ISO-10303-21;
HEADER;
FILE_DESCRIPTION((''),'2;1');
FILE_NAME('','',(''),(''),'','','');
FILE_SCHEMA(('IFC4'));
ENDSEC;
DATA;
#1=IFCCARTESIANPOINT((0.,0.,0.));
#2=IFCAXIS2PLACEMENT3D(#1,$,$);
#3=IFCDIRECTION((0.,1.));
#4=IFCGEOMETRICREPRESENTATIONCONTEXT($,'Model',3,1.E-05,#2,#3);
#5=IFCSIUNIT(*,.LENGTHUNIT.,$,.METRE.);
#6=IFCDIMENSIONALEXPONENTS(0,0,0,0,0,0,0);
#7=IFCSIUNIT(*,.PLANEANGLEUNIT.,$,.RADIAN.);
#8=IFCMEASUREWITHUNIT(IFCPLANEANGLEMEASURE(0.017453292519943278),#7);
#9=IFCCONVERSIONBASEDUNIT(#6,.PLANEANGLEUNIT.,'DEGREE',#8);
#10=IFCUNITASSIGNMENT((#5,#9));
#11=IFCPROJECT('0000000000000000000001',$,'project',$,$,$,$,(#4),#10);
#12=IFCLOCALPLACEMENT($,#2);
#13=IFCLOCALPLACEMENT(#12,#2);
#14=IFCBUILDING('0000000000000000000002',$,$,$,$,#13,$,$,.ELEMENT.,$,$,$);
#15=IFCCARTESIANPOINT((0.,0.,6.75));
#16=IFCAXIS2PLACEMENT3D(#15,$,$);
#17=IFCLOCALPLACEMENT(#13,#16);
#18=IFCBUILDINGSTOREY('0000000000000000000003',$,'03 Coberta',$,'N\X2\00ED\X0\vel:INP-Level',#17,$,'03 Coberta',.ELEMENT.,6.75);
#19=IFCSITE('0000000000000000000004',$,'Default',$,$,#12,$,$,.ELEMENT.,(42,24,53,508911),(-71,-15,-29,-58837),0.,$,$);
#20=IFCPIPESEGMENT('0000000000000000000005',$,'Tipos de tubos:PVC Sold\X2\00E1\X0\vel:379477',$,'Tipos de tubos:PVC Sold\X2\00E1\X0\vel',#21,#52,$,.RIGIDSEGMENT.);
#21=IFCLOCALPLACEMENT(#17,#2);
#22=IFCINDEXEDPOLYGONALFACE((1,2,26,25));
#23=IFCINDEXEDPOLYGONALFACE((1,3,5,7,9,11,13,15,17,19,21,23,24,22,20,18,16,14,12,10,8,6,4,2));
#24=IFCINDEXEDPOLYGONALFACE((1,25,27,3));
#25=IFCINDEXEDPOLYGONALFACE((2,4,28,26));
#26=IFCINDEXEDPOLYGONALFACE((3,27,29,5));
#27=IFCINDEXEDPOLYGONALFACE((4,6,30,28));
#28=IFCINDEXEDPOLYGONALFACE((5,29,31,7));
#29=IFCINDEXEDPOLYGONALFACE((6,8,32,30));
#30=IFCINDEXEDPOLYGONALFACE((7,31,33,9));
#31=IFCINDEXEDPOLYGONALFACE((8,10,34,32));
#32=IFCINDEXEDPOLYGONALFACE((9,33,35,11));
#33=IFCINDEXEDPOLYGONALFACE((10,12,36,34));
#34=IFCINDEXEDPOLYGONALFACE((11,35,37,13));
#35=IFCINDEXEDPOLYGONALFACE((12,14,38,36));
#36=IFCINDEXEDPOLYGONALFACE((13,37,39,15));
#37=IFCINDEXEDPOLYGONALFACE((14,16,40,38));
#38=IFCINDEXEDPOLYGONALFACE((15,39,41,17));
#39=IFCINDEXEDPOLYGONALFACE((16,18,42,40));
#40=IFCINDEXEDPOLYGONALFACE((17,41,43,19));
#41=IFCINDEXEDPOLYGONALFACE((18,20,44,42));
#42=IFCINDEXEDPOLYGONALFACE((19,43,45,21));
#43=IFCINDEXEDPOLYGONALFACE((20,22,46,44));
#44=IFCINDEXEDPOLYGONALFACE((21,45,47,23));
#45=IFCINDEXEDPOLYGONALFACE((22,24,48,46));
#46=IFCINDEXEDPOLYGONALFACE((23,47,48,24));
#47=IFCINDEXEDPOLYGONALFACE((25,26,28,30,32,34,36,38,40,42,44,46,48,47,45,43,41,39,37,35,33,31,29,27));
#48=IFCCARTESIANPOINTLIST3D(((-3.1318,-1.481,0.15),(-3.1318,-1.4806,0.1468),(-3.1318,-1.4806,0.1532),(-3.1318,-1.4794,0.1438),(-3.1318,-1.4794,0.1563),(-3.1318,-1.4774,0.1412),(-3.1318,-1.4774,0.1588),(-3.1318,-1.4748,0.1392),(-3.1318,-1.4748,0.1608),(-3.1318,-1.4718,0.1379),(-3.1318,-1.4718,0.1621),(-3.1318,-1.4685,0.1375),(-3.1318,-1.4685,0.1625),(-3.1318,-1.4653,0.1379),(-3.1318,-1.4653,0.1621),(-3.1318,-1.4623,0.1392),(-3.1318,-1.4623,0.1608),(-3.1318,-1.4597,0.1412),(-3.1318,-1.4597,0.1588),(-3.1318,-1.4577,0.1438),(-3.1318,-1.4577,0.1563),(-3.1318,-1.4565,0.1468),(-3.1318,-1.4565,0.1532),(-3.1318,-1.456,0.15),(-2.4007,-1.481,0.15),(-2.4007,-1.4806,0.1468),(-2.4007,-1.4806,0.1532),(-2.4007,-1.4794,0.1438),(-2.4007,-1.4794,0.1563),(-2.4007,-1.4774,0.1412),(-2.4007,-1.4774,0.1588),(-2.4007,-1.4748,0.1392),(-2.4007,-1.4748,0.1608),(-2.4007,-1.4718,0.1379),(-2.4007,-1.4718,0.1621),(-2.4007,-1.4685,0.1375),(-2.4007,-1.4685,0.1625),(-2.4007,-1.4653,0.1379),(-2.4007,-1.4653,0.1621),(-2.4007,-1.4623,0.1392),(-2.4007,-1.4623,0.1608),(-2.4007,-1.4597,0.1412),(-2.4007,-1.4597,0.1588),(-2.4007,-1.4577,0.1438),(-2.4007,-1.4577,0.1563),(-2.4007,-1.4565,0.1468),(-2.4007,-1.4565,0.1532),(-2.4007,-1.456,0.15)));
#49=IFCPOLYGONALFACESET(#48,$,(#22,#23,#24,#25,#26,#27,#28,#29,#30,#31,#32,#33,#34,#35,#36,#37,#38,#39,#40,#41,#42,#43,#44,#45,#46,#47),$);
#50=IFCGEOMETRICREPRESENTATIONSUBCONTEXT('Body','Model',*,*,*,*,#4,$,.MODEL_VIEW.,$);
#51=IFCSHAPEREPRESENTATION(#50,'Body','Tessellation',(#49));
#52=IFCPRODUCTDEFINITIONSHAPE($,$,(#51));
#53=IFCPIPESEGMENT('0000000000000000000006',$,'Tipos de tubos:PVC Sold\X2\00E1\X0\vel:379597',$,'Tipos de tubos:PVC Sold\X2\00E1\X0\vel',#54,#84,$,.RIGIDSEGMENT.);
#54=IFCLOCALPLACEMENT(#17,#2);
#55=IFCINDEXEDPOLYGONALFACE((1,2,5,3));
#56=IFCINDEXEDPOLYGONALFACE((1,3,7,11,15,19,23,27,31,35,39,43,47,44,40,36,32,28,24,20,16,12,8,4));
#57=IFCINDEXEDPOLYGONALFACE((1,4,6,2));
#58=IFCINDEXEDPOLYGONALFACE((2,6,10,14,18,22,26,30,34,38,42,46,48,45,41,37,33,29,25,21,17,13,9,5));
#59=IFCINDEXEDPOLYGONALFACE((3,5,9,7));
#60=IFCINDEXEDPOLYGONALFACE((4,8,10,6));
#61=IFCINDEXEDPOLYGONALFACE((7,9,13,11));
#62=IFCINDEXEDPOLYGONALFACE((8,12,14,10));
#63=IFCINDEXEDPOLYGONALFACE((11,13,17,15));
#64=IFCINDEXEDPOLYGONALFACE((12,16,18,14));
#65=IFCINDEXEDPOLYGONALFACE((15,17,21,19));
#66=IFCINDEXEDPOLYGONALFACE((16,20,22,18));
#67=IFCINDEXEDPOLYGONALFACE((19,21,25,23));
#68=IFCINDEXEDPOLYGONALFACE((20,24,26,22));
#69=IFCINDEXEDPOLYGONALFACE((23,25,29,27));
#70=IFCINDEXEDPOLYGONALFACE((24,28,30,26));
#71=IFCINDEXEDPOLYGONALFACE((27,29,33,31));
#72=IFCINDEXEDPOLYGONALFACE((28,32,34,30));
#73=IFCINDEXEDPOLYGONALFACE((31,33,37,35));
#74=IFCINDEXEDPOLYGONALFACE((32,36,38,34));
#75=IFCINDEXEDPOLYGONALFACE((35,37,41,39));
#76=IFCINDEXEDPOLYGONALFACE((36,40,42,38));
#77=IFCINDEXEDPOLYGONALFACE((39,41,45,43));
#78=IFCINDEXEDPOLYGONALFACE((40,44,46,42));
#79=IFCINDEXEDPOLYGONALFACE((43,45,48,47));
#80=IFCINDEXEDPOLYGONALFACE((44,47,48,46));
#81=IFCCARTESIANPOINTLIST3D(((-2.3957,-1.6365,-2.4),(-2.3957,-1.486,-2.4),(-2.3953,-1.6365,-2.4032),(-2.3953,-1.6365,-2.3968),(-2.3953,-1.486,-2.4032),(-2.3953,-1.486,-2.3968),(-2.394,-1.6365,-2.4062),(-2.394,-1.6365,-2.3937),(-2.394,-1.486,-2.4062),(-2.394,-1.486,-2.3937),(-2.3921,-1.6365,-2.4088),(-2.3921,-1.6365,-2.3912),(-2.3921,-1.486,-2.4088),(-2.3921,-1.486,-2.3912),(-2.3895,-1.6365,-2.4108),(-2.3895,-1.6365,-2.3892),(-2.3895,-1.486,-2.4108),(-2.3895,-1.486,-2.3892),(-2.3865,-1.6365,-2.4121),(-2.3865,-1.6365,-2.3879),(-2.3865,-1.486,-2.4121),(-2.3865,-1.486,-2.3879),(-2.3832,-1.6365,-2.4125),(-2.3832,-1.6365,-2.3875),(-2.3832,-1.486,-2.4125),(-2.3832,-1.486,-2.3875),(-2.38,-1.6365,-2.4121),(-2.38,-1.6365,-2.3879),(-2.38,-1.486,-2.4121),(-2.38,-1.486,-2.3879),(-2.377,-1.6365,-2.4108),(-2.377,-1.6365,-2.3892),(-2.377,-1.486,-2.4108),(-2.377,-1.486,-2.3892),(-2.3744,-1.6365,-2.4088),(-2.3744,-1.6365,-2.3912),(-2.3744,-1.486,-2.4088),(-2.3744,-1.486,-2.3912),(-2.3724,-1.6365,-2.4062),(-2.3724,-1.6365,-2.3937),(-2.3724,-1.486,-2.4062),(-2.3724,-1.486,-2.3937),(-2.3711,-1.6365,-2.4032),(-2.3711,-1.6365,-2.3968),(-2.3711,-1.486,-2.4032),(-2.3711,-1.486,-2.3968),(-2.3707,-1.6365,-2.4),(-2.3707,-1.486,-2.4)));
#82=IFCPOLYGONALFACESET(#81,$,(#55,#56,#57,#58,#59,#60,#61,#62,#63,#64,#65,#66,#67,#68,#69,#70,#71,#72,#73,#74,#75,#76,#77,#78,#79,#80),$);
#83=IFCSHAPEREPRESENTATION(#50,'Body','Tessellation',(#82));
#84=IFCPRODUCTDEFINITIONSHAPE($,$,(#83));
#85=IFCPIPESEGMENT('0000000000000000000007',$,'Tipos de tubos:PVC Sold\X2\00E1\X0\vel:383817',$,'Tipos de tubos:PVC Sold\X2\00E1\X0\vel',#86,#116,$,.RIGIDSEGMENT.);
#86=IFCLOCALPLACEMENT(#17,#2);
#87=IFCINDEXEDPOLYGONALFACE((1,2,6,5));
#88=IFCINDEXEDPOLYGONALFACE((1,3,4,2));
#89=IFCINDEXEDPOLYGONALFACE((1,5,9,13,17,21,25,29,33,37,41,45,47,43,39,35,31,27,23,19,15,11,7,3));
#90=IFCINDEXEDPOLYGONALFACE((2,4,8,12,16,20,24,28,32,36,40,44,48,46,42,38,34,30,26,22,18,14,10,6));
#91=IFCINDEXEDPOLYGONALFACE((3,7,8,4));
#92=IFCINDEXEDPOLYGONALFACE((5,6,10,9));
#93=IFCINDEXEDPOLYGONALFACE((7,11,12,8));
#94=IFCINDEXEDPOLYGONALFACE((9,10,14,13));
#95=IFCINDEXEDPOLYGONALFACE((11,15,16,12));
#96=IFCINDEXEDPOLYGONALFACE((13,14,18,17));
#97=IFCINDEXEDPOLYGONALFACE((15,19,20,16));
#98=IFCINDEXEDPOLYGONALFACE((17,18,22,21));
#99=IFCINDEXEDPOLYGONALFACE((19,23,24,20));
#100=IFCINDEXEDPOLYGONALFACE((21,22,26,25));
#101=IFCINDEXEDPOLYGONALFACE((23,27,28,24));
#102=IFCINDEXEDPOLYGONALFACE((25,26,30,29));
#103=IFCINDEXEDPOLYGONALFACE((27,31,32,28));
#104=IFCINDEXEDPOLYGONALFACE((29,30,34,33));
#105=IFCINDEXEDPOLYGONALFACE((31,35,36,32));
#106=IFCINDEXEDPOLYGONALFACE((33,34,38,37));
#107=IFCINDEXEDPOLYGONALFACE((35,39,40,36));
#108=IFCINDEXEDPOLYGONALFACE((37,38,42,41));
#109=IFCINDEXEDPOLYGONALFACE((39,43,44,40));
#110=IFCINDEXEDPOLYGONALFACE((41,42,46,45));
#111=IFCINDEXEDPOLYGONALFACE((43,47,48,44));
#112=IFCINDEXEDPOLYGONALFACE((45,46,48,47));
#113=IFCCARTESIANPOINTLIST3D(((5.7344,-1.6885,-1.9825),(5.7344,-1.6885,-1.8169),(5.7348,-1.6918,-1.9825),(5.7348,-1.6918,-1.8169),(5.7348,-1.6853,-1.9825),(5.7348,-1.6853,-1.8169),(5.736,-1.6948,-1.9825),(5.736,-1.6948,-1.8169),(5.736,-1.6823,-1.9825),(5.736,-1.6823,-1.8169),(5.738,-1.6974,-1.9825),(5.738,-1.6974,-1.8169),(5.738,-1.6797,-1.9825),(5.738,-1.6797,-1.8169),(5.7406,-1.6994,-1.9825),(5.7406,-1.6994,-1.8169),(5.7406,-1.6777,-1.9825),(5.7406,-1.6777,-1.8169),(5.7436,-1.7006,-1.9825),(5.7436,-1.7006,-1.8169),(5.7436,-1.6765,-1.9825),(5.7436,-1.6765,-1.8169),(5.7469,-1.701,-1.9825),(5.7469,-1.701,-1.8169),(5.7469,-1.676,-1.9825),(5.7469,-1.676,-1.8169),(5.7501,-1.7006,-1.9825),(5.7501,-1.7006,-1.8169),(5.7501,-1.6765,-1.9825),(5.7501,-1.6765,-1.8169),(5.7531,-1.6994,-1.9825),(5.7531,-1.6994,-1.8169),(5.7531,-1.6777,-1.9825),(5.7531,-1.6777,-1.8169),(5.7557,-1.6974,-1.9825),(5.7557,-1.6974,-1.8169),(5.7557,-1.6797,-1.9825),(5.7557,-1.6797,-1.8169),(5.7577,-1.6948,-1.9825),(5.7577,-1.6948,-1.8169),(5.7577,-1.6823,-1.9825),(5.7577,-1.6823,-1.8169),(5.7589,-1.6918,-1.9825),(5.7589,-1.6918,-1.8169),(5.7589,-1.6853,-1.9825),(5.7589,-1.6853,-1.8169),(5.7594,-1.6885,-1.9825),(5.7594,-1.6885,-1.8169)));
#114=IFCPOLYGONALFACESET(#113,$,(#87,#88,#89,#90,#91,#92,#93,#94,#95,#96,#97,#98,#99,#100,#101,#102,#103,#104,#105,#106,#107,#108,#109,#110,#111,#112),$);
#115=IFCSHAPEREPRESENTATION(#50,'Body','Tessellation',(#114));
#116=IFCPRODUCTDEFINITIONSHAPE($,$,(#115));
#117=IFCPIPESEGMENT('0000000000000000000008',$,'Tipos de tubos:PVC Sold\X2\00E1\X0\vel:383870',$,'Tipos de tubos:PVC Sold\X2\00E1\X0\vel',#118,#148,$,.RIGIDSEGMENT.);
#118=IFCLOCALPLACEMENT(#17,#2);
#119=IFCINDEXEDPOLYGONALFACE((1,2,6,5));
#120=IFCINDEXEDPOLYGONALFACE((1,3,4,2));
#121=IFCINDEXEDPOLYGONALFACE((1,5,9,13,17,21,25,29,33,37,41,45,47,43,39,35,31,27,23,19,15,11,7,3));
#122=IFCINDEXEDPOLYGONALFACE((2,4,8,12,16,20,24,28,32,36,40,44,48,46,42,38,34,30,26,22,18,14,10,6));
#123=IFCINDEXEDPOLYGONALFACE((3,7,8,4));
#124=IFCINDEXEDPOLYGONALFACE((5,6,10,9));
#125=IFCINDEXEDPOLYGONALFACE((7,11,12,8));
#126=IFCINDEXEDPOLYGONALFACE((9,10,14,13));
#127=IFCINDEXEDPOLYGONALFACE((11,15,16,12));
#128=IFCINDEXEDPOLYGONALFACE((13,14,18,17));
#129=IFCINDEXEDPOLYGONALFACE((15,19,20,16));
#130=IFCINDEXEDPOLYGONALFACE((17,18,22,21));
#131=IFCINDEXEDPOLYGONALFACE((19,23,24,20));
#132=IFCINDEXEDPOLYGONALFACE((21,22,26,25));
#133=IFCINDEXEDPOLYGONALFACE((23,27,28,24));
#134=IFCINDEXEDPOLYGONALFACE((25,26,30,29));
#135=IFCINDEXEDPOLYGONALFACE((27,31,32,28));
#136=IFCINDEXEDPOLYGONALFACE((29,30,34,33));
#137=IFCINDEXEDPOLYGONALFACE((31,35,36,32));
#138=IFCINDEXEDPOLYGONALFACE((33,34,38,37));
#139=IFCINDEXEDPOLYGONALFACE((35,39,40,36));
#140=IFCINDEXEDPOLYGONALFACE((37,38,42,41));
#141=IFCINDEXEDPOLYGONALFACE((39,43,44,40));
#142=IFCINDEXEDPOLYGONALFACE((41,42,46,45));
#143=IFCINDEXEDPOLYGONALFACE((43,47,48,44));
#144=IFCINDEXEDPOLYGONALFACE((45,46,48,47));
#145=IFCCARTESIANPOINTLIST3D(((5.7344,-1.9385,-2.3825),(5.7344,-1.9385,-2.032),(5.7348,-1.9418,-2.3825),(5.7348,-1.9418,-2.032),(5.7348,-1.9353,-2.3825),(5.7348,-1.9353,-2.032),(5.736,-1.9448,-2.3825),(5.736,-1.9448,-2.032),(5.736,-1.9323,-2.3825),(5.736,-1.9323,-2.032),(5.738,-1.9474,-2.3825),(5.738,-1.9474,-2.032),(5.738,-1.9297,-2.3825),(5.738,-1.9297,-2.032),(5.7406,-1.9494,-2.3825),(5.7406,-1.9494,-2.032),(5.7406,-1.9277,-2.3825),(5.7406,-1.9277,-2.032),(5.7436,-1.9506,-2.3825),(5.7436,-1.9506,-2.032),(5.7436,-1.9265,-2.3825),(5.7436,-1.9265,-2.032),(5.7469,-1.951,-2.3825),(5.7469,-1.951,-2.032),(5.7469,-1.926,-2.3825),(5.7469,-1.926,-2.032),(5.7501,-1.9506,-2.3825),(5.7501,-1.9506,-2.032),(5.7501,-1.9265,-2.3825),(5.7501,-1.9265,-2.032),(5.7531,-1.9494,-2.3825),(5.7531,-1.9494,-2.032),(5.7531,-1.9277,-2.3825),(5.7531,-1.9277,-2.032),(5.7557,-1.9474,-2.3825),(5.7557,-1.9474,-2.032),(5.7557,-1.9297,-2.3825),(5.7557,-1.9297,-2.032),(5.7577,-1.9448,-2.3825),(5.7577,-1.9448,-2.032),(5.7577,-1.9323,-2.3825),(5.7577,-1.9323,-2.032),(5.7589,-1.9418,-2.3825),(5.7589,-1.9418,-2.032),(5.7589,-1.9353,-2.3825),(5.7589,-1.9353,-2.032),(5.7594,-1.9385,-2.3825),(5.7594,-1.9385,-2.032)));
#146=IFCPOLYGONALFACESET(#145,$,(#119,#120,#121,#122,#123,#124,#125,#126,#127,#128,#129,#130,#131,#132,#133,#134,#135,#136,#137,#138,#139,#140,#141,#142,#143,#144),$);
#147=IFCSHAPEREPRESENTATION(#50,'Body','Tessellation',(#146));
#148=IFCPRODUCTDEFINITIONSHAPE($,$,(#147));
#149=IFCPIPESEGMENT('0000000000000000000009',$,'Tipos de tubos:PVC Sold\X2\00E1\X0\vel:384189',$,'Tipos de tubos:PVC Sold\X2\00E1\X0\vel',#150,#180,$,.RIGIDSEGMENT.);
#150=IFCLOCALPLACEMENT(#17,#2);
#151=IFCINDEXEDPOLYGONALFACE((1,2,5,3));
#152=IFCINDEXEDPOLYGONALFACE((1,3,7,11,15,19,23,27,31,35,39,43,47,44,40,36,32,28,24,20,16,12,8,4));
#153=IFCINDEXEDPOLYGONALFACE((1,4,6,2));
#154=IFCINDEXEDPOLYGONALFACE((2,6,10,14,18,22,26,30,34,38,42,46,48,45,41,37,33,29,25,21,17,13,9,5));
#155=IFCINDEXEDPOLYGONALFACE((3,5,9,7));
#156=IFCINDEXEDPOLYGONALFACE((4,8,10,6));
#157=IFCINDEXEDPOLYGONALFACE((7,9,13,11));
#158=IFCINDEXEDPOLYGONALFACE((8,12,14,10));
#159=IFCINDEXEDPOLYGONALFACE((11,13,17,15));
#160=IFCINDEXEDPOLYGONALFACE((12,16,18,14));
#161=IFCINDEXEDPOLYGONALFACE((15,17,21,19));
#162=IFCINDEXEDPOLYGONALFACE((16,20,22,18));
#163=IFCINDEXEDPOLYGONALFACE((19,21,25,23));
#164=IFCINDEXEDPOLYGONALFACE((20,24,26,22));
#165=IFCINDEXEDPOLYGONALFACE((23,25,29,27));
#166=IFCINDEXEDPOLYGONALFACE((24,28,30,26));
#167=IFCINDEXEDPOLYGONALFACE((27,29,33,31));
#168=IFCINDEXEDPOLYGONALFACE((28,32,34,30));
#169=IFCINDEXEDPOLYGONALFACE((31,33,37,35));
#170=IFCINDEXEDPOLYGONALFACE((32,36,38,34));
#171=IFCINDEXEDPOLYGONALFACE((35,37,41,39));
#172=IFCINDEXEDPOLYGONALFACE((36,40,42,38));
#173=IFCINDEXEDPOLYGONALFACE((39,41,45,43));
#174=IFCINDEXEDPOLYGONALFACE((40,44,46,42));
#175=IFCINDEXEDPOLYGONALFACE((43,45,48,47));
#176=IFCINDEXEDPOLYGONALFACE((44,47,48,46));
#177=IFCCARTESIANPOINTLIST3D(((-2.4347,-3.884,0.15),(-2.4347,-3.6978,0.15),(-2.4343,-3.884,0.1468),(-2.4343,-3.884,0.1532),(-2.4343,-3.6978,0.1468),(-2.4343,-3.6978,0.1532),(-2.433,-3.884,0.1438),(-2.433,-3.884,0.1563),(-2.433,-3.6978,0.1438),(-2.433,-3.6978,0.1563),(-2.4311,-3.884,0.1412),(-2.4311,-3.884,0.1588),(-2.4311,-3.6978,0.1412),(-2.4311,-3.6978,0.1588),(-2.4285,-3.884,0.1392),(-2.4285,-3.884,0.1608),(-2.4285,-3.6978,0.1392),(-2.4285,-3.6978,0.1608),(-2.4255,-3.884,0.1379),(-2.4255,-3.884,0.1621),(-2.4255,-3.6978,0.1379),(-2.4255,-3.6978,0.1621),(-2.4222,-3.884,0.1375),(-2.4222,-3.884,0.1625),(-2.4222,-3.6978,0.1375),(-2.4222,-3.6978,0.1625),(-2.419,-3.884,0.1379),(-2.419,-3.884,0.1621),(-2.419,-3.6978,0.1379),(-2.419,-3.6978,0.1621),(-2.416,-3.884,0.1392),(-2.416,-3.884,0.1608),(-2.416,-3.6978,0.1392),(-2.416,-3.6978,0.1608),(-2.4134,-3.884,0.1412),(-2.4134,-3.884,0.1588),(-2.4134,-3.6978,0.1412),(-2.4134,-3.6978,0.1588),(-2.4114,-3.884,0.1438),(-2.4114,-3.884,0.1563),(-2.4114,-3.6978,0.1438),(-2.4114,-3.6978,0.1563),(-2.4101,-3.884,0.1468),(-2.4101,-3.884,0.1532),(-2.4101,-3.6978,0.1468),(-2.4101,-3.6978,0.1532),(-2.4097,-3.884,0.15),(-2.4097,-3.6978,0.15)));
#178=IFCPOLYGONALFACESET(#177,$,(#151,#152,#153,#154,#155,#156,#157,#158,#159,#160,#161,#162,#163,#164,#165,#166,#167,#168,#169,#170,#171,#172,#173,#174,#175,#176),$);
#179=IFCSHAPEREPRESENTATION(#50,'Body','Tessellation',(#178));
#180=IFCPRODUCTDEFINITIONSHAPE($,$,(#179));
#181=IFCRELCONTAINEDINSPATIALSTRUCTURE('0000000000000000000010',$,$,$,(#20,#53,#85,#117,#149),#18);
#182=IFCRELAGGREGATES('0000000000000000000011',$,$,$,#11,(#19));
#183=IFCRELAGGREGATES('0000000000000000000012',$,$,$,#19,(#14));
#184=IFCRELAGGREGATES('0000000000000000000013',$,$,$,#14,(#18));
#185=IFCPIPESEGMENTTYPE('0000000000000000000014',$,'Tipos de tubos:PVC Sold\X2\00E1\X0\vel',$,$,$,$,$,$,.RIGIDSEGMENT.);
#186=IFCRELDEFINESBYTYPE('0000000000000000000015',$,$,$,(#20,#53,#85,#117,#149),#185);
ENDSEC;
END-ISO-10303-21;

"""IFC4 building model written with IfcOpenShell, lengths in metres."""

from ifc_helpers import new_model, entity, si_unit, converted_unit, direction, frame, origin, place, context, subcontext, project, spatial, arc, indexed_curve, outline, extrude, type_object, element, save


model = new_model("IFC4")

# Units and contexts
model_context = context("Model", 3, precision=1e-05, world=origin(), true_north=direction((0.0, 1.0)))
body_context = subcontext(model_context, "Body", "Model", "MODEL_VIEW")
ifc_project = project(units=[si_unit("LENGTHUNIT", "METRE"), converted_unit("PLANEANGLEUNIT", "DEGREE", entity("IfcPlaneAngleMeasure", 0.017453292519943278), si_unit("PLANEANGLEUNIT", "RADIAN"), dimensions=[0, 0, 0, 0, 0, 0, 0])], contexts=[model_context])

# Site, building, storey
site_placement = place(None, origin())
site = spatial("IfcSite", under=ifc_project, at=site_placement, Name="Default", CompositionType="ELEMENT", RefLatitude=(42, 24, 53, 508911), RefLongitude=(-71, -15, -29, -58837), RefElevation=0.0)
building_placement = place(site_placement, origin())
building = spatial("IfcBuilding", under=site, at=building_placement, CompositionType="ELEMENT")
storey_placement = place(building_placement, frame((0.0, 0.0, 6.75)))
storey = spatial("IfcBuildingStorey", under=building, at=storey_placement, Name="03 Coberta", ObjectType="Nível:INP-Level", LongName="03 Coberta", CompositionType="ELEMENT", Elevation=6.75)

# Pipe segments
pipe_segment_type = type_object("IfcPipeSegmentType", Name="Tipos de tubos:PVC Soldável", PredefinedType="RIGIDSEGMENT")
pipe_segment_1_placement = place(storey_placement, origin())
element("IfcPipeSegment", 1, at=pipe_segment_1_placement, inside=storey, type_object=pipe_segment_type, Name="Tipos de tubos:PVC Soldável:379477", ObjectType="Tipos de tubos:PVC Soldável", PredefinedType="RIGIDSEGMENT", context=body_context, shape_type="SweptSolid", body=[
    extrude(outline(indexed_curve([(0.0125, 0.0), (0.0088, 0.0088), (0.0, 0.0125), (-0.0088, 0.0088), (-0.0125, 0.0), (-0.0088, -0.0088), (0.0, -0.0125), (0.0088, -0.0088)], segments=[arc(1, 2, 3), arc(3, 4, 5), arc(5, 6, 7), arc(7, 8, 1)], self_intersect=False)), frame((-3.1318, -1.4685, 0.15), z_axis=(1.0, 0.0, 0.0), x_axis=(0.0, 1.0, 0.0)), (0.0, 0.0, 1.0), 0.7311),
])
pipe_segment_2_placement = place(storey_placement, origin())
element("IfcPipeSegment", 2, at=pipe_segment_2_placement, inside=storey, type_object=pipe_segment_type, Name="Tipos de tubos:PVC Soldável:379597", ObjectType="Tipos de tubos:PVC Soldável", PredefinedType="RIGIDSEGMENT", context=body_context, shape_type="SweptSolid", body=[
    extrude(outline(indexed_curve([(0.0125, 0.0), (0.0088, 0.0088), (0.0, 0.0125), (-0.0088, 0.0088), (-0.0125, 0.0), (-0.0088, -0.0088), (0.0, -0.0125), (0.0088, -0.0088)], segments=[arc(1, 2, 3), arc(3, 4, 5), arc(5, 6, 7), arc(7, 8, 1)], self_intersect=False)), frame((-2.3832, -1.6365, -2.4), z_axis=(0.0, 1.0, 0.0), x_axis=(-1.0, 0.0, 0.0)), (0.0, 0.0, 1.0), 0.1505),
])
pipe_segment_3_placement = place(storey_placement, origin())
element("IfcPipeSegment", 3, at=pipe_segment_3_placement, inside=storey, type_object=pipe_segment_type, Name="Tipos de tubos:PVC Soldável:383817", ObjectType="Tipos de tubos:PVC Soldável", PredefinedType="RIGIDSEGMENT", context=body_context, shape_type="SweptSolid", body=[
    extrude(outline(indexed_curve([(0.0125, 0.0), (0.0088, 0.0088), (0.0, 0.0125), (-0.0088, 0.0088), (-0.0125, 0.0), (-0.0088, -0.0088), (0.0, -0.0125), (0.0088, -0.0088)], segments=[arc(1, 2, 3), arc(3, 4, 5), arc(5, 6, 7), arc(7, 8, 1)], self_intersect=False)), frame((5.7469, -1.6885, -1.9825), z_axis=(0.0, 0.0, 1.0), x_axis=(-1.0, 0.0, 0.0)), (0.0, 0.0, 1.0), 0.1656),
])
pipe_segment_4_placement = place(storey_placement, origin())
element("IfcPipeSegment", 4, at=pipe_segment_4_placement, inside=storey, type_object=pipe_segment_type, Name="Tipos de tubos:PVC Soldável:383870", ObjectType="Tipos de tubos:PVC Soldável", PredefinedType="RIGIDSEGMENT", context=body_context, shape_type="SweptSolid", body=[
    extrude(outline(indexed_curve([(0.0125, 0.0), (0.0088, 0.0088), (0.0, 0.0125), (-0.0088, 0.0088), (-0.0125, 0.0), (-0.0088, -0.0088), (0.0, -0.0125), (0.0088, -0.0088)], segments=[arc(1, 2, 3), arc(3, 4, 5), arc(5, 6, 7), arc(7, 8, 1)], self_intersect=False)), frame((5.7469, -1.9385, -2.3825)), (0.0, 0.0, 1.0), 0.3505),
])
pipe_segment_5_placement = place(storey_placement, origin())
element("IfcPipeSegment", 5, at=pipe_segment_5_placement, inside=storey, type_object=pipe_segment_type, Name="Tipos de tubos:PVC Soldável:384189", ObjectType="Tipos de tubos:PVC Soldável", PredefinedType="RIGIDSEGMENT", context=body_context, shape_type="SweptSolid", body=[
    extrude(outline(indexed_curve([(0.0125, 0.0), (0.0088, 0.0088), (0.0, 0.0125), (-0.0088, 0.0088), (-0.0125, 0.0), (-0.0088, -0.0088), (0.0, -0.0125), (0.0088, -0.0088)], segments=[arc(1, 2, 3), arc(3, 4, 5), arc(5, 6, 7), arc(7, 8, 1)], self_intersect=False)), frame((-2.4222, -3.884, 0.15), z_axis=(0.0, 1.0, 0.0), x_axis=(-1.0, 0.0, 0.0)), (0.0, 0.0, 1.0), 0.1862),
])

save(model, "model.ifc")
